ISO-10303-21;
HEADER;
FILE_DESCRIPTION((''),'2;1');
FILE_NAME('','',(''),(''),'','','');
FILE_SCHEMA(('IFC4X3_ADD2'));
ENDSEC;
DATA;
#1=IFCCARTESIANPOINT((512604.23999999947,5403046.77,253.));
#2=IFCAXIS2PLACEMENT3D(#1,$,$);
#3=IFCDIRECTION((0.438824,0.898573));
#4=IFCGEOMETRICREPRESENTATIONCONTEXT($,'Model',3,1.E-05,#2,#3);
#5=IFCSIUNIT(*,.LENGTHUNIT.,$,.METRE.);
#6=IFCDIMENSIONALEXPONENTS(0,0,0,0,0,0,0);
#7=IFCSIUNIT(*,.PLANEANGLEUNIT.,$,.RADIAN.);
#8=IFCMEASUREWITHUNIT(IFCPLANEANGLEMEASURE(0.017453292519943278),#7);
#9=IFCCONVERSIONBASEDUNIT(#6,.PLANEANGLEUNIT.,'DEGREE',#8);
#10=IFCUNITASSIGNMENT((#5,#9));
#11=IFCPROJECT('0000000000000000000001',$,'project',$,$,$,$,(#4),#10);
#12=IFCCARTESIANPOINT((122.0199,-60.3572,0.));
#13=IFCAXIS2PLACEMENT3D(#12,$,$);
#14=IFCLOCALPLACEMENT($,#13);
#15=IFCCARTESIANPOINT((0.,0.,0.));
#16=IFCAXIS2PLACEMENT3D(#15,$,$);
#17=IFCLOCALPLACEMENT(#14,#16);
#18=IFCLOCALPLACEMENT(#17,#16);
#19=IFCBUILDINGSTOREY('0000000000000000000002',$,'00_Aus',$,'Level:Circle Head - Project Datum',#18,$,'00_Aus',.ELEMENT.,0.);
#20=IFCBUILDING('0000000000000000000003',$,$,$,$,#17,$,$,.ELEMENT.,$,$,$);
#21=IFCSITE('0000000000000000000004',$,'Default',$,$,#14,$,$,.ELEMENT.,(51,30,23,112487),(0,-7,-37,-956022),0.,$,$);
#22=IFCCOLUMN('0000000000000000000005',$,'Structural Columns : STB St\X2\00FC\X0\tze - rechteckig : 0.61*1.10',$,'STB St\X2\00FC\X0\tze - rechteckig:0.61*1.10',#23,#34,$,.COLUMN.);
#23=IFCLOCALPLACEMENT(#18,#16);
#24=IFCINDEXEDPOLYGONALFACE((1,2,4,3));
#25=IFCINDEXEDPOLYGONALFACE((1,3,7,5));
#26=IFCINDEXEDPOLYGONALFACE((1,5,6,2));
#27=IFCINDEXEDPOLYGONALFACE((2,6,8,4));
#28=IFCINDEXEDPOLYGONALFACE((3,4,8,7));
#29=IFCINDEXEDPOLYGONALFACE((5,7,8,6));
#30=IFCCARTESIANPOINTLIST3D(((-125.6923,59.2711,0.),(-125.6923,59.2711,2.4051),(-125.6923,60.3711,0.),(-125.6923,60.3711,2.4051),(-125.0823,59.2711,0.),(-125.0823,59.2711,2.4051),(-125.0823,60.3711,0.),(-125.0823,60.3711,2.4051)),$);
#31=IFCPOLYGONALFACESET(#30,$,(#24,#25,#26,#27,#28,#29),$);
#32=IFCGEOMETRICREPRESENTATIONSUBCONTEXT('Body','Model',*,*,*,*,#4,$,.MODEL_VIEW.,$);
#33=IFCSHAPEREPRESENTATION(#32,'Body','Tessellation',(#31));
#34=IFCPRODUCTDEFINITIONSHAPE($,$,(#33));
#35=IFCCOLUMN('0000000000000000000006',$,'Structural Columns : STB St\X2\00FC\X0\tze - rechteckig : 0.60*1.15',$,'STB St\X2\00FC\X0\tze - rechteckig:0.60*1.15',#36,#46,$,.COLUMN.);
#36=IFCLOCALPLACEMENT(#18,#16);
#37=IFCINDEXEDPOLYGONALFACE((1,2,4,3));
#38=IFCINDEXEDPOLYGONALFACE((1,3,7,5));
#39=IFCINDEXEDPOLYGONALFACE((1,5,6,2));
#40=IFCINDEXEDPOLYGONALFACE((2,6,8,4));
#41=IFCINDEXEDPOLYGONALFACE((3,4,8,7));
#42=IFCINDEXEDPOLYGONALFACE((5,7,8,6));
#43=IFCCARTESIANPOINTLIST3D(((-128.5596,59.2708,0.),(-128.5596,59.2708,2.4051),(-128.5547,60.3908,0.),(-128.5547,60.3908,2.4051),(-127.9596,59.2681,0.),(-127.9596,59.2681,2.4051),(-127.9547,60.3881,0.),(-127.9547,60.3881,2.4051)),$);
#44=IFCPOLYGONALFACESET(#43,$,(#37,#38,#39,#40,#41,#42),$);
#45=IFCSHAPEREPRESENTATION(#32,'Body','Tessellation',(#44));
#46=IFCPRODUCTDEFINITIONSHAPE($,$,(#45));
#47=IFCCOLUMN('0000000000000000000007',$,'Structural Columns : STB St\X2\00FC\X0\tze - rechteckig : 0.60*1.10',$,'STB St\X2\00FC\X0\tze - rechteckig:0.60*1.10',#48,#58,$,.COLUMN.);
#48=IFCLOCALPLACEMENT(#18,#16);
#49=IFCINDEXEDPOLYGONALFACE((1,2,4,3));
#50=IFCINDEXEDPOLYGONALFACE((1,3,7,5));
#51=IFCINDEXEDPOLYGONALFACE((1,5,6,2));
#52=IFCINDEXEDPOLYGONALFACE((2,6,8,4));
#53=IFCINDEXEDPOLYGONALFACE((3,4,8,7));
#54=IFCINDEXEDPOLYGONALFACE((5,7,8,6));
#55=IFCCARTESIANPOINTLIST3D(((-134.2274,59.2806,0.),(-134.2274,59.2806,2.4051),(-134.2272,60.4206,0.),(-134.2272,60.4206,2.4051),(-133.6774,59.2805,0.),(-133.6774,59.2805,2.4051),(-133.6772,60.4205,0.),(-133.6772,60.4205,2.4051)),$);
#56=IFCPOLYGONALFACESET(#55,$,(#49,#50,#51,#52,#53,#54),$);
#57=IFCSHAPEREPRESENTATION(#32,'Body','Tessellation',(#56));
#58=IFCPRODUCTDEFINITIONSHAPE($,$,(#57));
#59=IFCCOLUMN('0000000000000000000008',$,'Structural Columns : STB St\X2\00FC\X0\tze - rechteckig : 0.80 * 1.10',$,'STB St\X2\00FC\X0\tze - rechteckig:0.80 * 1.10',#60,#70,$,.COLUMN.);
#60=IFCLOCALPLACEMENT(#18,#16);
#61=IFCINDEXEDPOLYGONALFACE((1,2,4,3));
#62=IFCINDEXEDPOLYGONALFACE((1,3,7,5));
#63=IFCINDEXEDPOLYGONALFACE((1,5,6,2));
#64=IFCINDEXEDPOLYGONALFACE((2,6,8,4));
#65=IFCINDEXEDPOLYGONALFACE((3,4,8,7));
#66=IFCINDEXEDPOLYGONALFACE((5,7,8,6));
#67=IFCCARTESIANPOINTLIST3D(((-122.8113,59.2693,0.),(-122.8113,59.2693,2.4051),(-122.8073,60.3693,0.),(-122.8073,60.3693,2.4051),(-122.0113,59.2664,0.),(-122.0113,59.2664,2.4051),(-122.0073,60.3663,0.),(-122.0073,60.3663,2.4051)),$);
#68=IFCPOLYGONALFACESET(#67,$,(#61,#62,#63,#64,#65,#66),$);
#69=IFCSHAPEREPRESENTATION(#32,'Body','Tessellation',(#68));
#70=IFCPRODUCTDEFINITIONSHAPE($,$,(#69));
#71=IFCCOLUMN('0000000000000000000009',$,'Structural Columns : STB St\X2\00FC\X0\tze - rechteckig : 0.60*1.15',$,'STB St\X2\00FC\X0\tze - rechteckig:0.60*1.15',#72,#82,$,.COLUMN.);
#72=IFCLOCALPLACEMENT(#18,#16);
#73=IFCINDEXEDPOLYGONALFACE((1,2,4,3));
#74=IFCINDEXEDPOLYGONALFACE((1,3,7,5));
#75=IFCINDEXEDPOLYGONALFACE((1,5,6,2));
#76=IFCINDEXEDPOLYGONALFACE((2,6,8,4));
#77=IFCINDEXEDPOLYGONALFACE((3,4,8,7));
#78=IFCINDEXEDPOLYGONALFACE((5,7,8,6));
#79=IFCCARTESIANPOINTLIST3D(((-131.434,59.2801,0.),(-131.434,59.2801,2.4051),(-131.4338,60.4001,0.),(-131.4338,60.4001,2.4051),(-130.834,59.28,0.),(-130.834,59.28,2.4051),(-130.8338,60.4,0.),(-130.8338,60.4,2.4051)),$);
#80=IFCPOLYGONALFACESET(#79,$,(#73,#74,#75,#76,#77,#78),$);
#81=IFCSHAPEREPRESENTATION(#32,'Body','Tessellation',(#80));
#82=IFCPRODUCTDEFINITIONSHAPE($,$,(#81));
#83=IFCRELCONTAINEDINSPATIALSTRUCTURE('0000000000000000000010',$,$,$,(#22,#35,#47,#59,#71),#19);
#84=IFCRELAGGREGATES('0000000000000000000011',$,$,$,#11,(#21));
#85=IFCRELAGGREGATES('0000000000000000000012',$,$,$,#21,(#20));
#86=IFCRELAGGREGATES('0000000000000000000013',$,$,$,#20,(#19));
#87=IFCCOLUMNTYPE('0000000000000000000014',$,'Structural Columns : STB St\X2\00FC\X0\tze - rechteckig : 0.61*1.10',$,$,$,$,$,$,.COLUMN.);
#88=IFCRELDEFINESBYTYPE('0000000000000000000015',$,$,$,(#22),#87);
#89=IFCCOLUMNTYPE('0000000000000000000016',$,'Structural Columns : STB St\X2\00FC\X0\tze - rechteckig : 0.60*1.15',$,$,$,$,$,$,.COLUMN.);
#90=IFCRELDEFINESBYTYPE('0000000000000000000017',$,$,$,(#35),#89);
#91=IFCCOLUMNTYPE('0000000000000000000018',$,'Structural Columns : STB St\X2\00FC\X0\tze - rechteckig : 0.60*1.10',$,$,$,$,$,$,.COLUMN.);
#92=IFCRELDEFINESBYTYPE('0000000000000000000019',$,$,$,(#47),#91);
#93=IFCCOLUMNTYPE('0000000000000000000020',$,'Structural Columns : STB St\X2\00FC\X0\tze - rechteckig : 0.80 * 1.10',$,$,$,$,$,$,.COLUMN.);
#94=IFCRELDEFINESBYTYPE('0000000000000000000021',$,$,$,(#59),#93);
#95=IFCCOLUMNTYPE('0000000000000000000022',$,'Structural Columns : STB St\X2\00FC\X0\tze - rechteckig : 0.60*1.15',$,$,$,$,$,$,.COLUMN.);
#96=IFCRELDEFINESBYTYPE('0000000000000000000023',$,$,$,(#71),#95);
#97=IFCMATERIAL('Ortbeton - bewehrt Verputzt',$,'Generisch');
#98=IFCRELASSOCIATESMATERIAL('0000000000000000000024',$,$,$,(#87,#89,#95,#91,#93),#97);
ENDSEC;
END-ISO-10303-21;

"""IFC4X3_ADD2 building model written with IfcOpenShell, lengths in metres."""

from ifc_helpers import new_model, entity, si_unit, converted_unit, direction, frame, frame_2d, origin, origin_2d_with_axis, place, context, subcontext, project, spatial, rectangle, extrude, source, transform, mapped, material, material_profile, profile_set, type_object, type_shapes, element, save


model = new_model("IFC4X3_ADD2")

# Units and contexts
model_context = context("Model", 3, precision=1e-05, world=frame((512604.23999999947, 5403046.77, 253.0)), true_north=direction((0.438824, 0.898573)))
body_context = subcontext(model_context, "Body", "Model", "MODEL_VIEW")
ifc_project = project(units=[si_unit("LENGTHUNIT", "METRE"), converted_unit("PLANEANGLEUNIT", "DEGREE", entity("IfcPlaneAngleMeasure", 0.017453292519943278), si_unit("PLANEANGLEUNIT", "RADIAN"), dimensions=[0, 0, 0, 0, 0, 0, 0])], contexts=[model_context])

# Site, building, storey
site_placement = place(None, frame((122.0199, -60.3572, 0.0)))
site = spatial("IfcSite", under=ifc_project, at=site_placement, Name="Default", CompositionType="ELEMENT", RefLatitude=(51, 30, 23, 112487), RefLongitude=(0, -7, -37, -956022), RefElevation=0.0)
building_placement = place(site_placement, origin())
building = spatial("IfcBuilding", under=site, at=building_placement, CompositionType="ELEMENT")
storey_placement = place(building_placement, origin())
storey = spatial("IfcBuildingStorey", under=building, at=storey_placement, Name="00_Aus", ObjectType="Level:Circle Head - Project Datum", LongName="00_Aus", CompositionType="ELEMENT", Elevation=0.0)

# Columns
ifc_material_1 = material(Name="Ortbeton - bewehrt Verputzt", Category="Generisch")
ifc_material_profile_1 = material_profile(ifc_material_1, rectangle(XDim=0.61, YDim=1.1, at=frame_2d((0.0, 0.0), x_axis=(1.0, 0.0))), Name="0.61*1.10")
ifc_profile_set_1 = profile_set([ifc_material_profile_1], Name="0.61*1.10")
column_type_1 = type_object("IfcColumnType", Name="Structural Columns : STB Stütze - rechteckig : 0.61*1.10", PredefinedType="COLUMN", material=ifc_profile_set_1)
shared_shape_1 = source(origin(), body_context, "Body", "SweptSolid", [
    extrude(rectangle(XDim=0.61, YDim=1.1, at=frame_2d((0.0, 0.0), x_axis=(1.0, 0.0))), frame((-125.3873, 59.8211, 0.0), z_axis=(0.0, 0.0, 1.0), x_axis=(-1.0, 0.0, 0.0)), (0.0, 0.0, 1.0), 2.4051),
])
type_shapes(column_type_1, [shared_shape_1])
column_1_placement = place(storey_placement, origin())
element("IfcColumn", 1, at=column_1_placement, inside=storey, type_object=column_type_1, Name="Structural Columns : STB Stütze - rechteckig : 0.61*1.10", ObjectType="STB Stütze - rechteckig:0.61*1.10", PredefinedType="COLUMN", context=body_context, shape_type="MappedRepresentation", body=[
    mapped(shared_shape_1, transform((0.0, 0.0, 0.0), scale=1.0)),
])
ifc_material_profile_2 = material_profile(ifc_material_1, rectangle(XDim=2.4051, YDim=1.12, at=frame_2d((0.0, 0.0), x_axis=(1.0, 0.0))), Name="0.60*1.15")
ifc_profile_set_2 = profile_set([ifc_material_profile_2], Name="0.60*1.15")
column_type_2 = type_object("IfcColumnType", Name="Structural Columns : STB Stütze - rechteckig : 0.60*1.15", PredefinedType="COLUMN", material=ifc_profile_set_2)
shared_shape_2 = source(origin(), body_context, "Body", "SweptSolid", [
    extrude(rectangle(XDim=2.4051, YDim=1.12, at=frame_2d((0.0, 0.0), x_axis=(1.0, 0.0))), frame((-128.5571, 59.8308, 1.2026), z_axis=(0.99999, -0.004391, 0.0), x_axis=(0.0, 0.0, 1.0)), (0.0, 0.0, 1.0), 0.6),
])
type_shapes(column_type_2, [shared_shape_2])
column_2_placement = place(storey_placement, origin())
element("IfcColumn", 2, at=column_2_placement, inside=storey, type_object=column_type_2, Name="Structural Columns : STB Stütze - rechteckig : 0.60*1.15", ObjectType="STB Stütze - rechteckig:0.60*1.15", PredefinedType="COLUMN", context=body_context, shape_type="MappedRepresentation", body=[
    mapped(shared_shape_2, transform((0.0, 0.0, 0.0), scale=1.0)),
])
ifc_material_profile_3 = material_profile(ifc_material_1, rectangle(XDim=2.4051, YDim=1.14, at=origin_2d_with_axis()), Name="0.60*1.10")
ifc_profile_set_3 = profile_set([ifc_material_profile_3], Name="0.60*1.10")
column_type_3 = type_object("IfcColumnType", Name="Structural Columns : STB Stütze - rechteckig : 0.60*1.10", PredefinedType="COLUMN", material=ifc_profile_set_3)
shared_shape_3 = source(origin(), body_context, "Body", "SweptSolid", [
    extrude(rectangle(XDim=2.4051, YDim=1.14, at=origin_2d_with_axis()), frame((-134.2273, 59.8506, 1.2026), z_axis=(1.0, -0.000163, 0.0), x_axis=(0.0, 0.0, 1.0)), (0.0, 0.0, 1.0), 0.55),
])
type_shapes(column_type_3, [shared_shape_3])
column_3_placement = place(storey_placement, origin())
element("IfcColumn", 3, at=column_3_placement, inside=storey, type_object=column_type_3, Name="Structural Columns : STB Stütze - rechteckig : 0.60*1.10", ObjectType="STB Stütze - rechteckig:0.60*1.10", PredefinedType="COLUMN", context=body_context, shape_type="MappedRepresentation", body=[
    mapped(shared_shape_3, transform((0.0, 0.0, 0.0), scale=1.0)),
])
ifc_material_profile_4 = material_profile(ifc_material_1, rectangle(XDim=2.4051, YDim=1.1, at=frame_2d((0.0, 0.0), x_axis=(1.0, 0.0))), Name="0.80 * 1.10")
ifc_profile_set_4 = profile_set([ifc_material_profile_4], Name="0.80 * 1.10")
column_type_4 = type_object("IfcColumnType", Name="Structural Columns : STB Stütze - rechteckig : 0.80 * 1.10", PredefinedType="COLUMN", material=ifc_profile_set_4)
shared_shape_4 = source(origin(), body_context, "Body", "SweptSolid", [
    extrude(rectangle(XDim=2.4051, YDim=1.1, at=frame_2d((0.0, 0.0), x_axis=(1.0, 0.0))), frame((-122.8093, 59.8193, 1.2026), z_axis=(0.999993, -0.003646, 0.0), x_axis=(0.0, 0.0, 1.0)), (0.0, 0.0, 1.0), 0.8),
])
type_shapes(column_type_4, [shared_shape_4])
column_4_placement = place(storey_placement, origin())
element("IfcColumn", 4, at=column_4_placement, inside=storey, type_object=column_type_4, Name="Structural Columns : STB Stütze - rechteckig : 0.80 * 1.10", ObjectType="STB Stütze - rechteckig:0.80 * 1.10", PredefinedType="COLUMN", context=body_context, shape_type="MappedRepresentation", body=[
    mapped(shared_shape_4, transform((0.0, 0.0, 0.0), scale=1.0)),
])
column_type_5 = type_object("IfcColumnType", Name="Structural Columns : STB Stütze - rechteckig : 0.60*1.15", PredefinedType="COLUMN", material=ifc_profile_set_2)
shared_shape_5 = source(origin(), body_context, "Body", "SweptSolid", [
    extrude(rectangle(XDim=2.4051, YDim=1.12, at=frame_2d((0.0, 0.0), x_axis=(1.0, 0.0))), frame((-131.4339, 59.8401, 1.2026), z_axis=(1.0, -0.000163, 0.0), x_axis=(0.0, 0.0, 1.0)), (0.0, 0.0, 1.0), 0.6),
])
type_shapes(column_type_5, [shared_shape_5])
column_5_placement = place(storey_placement, origin())
element("IfcColumn", 5, at=column_5_placement, inside=storey, type_object=column_type_5, Name="Structural Columns : STB Stütze - rechteckig : 0.60*1.15", ObjectType="STB Stütze - rechteckig:0.60*1.15", PredefinedType="COLUMN", context=body_context, shape_type="MappedRepresentation", body=[
    mapped(shared_shape_5, transform((0.0, 0.0, 0.0), scale=1.0)),
])

save(model, "model.ifc")
